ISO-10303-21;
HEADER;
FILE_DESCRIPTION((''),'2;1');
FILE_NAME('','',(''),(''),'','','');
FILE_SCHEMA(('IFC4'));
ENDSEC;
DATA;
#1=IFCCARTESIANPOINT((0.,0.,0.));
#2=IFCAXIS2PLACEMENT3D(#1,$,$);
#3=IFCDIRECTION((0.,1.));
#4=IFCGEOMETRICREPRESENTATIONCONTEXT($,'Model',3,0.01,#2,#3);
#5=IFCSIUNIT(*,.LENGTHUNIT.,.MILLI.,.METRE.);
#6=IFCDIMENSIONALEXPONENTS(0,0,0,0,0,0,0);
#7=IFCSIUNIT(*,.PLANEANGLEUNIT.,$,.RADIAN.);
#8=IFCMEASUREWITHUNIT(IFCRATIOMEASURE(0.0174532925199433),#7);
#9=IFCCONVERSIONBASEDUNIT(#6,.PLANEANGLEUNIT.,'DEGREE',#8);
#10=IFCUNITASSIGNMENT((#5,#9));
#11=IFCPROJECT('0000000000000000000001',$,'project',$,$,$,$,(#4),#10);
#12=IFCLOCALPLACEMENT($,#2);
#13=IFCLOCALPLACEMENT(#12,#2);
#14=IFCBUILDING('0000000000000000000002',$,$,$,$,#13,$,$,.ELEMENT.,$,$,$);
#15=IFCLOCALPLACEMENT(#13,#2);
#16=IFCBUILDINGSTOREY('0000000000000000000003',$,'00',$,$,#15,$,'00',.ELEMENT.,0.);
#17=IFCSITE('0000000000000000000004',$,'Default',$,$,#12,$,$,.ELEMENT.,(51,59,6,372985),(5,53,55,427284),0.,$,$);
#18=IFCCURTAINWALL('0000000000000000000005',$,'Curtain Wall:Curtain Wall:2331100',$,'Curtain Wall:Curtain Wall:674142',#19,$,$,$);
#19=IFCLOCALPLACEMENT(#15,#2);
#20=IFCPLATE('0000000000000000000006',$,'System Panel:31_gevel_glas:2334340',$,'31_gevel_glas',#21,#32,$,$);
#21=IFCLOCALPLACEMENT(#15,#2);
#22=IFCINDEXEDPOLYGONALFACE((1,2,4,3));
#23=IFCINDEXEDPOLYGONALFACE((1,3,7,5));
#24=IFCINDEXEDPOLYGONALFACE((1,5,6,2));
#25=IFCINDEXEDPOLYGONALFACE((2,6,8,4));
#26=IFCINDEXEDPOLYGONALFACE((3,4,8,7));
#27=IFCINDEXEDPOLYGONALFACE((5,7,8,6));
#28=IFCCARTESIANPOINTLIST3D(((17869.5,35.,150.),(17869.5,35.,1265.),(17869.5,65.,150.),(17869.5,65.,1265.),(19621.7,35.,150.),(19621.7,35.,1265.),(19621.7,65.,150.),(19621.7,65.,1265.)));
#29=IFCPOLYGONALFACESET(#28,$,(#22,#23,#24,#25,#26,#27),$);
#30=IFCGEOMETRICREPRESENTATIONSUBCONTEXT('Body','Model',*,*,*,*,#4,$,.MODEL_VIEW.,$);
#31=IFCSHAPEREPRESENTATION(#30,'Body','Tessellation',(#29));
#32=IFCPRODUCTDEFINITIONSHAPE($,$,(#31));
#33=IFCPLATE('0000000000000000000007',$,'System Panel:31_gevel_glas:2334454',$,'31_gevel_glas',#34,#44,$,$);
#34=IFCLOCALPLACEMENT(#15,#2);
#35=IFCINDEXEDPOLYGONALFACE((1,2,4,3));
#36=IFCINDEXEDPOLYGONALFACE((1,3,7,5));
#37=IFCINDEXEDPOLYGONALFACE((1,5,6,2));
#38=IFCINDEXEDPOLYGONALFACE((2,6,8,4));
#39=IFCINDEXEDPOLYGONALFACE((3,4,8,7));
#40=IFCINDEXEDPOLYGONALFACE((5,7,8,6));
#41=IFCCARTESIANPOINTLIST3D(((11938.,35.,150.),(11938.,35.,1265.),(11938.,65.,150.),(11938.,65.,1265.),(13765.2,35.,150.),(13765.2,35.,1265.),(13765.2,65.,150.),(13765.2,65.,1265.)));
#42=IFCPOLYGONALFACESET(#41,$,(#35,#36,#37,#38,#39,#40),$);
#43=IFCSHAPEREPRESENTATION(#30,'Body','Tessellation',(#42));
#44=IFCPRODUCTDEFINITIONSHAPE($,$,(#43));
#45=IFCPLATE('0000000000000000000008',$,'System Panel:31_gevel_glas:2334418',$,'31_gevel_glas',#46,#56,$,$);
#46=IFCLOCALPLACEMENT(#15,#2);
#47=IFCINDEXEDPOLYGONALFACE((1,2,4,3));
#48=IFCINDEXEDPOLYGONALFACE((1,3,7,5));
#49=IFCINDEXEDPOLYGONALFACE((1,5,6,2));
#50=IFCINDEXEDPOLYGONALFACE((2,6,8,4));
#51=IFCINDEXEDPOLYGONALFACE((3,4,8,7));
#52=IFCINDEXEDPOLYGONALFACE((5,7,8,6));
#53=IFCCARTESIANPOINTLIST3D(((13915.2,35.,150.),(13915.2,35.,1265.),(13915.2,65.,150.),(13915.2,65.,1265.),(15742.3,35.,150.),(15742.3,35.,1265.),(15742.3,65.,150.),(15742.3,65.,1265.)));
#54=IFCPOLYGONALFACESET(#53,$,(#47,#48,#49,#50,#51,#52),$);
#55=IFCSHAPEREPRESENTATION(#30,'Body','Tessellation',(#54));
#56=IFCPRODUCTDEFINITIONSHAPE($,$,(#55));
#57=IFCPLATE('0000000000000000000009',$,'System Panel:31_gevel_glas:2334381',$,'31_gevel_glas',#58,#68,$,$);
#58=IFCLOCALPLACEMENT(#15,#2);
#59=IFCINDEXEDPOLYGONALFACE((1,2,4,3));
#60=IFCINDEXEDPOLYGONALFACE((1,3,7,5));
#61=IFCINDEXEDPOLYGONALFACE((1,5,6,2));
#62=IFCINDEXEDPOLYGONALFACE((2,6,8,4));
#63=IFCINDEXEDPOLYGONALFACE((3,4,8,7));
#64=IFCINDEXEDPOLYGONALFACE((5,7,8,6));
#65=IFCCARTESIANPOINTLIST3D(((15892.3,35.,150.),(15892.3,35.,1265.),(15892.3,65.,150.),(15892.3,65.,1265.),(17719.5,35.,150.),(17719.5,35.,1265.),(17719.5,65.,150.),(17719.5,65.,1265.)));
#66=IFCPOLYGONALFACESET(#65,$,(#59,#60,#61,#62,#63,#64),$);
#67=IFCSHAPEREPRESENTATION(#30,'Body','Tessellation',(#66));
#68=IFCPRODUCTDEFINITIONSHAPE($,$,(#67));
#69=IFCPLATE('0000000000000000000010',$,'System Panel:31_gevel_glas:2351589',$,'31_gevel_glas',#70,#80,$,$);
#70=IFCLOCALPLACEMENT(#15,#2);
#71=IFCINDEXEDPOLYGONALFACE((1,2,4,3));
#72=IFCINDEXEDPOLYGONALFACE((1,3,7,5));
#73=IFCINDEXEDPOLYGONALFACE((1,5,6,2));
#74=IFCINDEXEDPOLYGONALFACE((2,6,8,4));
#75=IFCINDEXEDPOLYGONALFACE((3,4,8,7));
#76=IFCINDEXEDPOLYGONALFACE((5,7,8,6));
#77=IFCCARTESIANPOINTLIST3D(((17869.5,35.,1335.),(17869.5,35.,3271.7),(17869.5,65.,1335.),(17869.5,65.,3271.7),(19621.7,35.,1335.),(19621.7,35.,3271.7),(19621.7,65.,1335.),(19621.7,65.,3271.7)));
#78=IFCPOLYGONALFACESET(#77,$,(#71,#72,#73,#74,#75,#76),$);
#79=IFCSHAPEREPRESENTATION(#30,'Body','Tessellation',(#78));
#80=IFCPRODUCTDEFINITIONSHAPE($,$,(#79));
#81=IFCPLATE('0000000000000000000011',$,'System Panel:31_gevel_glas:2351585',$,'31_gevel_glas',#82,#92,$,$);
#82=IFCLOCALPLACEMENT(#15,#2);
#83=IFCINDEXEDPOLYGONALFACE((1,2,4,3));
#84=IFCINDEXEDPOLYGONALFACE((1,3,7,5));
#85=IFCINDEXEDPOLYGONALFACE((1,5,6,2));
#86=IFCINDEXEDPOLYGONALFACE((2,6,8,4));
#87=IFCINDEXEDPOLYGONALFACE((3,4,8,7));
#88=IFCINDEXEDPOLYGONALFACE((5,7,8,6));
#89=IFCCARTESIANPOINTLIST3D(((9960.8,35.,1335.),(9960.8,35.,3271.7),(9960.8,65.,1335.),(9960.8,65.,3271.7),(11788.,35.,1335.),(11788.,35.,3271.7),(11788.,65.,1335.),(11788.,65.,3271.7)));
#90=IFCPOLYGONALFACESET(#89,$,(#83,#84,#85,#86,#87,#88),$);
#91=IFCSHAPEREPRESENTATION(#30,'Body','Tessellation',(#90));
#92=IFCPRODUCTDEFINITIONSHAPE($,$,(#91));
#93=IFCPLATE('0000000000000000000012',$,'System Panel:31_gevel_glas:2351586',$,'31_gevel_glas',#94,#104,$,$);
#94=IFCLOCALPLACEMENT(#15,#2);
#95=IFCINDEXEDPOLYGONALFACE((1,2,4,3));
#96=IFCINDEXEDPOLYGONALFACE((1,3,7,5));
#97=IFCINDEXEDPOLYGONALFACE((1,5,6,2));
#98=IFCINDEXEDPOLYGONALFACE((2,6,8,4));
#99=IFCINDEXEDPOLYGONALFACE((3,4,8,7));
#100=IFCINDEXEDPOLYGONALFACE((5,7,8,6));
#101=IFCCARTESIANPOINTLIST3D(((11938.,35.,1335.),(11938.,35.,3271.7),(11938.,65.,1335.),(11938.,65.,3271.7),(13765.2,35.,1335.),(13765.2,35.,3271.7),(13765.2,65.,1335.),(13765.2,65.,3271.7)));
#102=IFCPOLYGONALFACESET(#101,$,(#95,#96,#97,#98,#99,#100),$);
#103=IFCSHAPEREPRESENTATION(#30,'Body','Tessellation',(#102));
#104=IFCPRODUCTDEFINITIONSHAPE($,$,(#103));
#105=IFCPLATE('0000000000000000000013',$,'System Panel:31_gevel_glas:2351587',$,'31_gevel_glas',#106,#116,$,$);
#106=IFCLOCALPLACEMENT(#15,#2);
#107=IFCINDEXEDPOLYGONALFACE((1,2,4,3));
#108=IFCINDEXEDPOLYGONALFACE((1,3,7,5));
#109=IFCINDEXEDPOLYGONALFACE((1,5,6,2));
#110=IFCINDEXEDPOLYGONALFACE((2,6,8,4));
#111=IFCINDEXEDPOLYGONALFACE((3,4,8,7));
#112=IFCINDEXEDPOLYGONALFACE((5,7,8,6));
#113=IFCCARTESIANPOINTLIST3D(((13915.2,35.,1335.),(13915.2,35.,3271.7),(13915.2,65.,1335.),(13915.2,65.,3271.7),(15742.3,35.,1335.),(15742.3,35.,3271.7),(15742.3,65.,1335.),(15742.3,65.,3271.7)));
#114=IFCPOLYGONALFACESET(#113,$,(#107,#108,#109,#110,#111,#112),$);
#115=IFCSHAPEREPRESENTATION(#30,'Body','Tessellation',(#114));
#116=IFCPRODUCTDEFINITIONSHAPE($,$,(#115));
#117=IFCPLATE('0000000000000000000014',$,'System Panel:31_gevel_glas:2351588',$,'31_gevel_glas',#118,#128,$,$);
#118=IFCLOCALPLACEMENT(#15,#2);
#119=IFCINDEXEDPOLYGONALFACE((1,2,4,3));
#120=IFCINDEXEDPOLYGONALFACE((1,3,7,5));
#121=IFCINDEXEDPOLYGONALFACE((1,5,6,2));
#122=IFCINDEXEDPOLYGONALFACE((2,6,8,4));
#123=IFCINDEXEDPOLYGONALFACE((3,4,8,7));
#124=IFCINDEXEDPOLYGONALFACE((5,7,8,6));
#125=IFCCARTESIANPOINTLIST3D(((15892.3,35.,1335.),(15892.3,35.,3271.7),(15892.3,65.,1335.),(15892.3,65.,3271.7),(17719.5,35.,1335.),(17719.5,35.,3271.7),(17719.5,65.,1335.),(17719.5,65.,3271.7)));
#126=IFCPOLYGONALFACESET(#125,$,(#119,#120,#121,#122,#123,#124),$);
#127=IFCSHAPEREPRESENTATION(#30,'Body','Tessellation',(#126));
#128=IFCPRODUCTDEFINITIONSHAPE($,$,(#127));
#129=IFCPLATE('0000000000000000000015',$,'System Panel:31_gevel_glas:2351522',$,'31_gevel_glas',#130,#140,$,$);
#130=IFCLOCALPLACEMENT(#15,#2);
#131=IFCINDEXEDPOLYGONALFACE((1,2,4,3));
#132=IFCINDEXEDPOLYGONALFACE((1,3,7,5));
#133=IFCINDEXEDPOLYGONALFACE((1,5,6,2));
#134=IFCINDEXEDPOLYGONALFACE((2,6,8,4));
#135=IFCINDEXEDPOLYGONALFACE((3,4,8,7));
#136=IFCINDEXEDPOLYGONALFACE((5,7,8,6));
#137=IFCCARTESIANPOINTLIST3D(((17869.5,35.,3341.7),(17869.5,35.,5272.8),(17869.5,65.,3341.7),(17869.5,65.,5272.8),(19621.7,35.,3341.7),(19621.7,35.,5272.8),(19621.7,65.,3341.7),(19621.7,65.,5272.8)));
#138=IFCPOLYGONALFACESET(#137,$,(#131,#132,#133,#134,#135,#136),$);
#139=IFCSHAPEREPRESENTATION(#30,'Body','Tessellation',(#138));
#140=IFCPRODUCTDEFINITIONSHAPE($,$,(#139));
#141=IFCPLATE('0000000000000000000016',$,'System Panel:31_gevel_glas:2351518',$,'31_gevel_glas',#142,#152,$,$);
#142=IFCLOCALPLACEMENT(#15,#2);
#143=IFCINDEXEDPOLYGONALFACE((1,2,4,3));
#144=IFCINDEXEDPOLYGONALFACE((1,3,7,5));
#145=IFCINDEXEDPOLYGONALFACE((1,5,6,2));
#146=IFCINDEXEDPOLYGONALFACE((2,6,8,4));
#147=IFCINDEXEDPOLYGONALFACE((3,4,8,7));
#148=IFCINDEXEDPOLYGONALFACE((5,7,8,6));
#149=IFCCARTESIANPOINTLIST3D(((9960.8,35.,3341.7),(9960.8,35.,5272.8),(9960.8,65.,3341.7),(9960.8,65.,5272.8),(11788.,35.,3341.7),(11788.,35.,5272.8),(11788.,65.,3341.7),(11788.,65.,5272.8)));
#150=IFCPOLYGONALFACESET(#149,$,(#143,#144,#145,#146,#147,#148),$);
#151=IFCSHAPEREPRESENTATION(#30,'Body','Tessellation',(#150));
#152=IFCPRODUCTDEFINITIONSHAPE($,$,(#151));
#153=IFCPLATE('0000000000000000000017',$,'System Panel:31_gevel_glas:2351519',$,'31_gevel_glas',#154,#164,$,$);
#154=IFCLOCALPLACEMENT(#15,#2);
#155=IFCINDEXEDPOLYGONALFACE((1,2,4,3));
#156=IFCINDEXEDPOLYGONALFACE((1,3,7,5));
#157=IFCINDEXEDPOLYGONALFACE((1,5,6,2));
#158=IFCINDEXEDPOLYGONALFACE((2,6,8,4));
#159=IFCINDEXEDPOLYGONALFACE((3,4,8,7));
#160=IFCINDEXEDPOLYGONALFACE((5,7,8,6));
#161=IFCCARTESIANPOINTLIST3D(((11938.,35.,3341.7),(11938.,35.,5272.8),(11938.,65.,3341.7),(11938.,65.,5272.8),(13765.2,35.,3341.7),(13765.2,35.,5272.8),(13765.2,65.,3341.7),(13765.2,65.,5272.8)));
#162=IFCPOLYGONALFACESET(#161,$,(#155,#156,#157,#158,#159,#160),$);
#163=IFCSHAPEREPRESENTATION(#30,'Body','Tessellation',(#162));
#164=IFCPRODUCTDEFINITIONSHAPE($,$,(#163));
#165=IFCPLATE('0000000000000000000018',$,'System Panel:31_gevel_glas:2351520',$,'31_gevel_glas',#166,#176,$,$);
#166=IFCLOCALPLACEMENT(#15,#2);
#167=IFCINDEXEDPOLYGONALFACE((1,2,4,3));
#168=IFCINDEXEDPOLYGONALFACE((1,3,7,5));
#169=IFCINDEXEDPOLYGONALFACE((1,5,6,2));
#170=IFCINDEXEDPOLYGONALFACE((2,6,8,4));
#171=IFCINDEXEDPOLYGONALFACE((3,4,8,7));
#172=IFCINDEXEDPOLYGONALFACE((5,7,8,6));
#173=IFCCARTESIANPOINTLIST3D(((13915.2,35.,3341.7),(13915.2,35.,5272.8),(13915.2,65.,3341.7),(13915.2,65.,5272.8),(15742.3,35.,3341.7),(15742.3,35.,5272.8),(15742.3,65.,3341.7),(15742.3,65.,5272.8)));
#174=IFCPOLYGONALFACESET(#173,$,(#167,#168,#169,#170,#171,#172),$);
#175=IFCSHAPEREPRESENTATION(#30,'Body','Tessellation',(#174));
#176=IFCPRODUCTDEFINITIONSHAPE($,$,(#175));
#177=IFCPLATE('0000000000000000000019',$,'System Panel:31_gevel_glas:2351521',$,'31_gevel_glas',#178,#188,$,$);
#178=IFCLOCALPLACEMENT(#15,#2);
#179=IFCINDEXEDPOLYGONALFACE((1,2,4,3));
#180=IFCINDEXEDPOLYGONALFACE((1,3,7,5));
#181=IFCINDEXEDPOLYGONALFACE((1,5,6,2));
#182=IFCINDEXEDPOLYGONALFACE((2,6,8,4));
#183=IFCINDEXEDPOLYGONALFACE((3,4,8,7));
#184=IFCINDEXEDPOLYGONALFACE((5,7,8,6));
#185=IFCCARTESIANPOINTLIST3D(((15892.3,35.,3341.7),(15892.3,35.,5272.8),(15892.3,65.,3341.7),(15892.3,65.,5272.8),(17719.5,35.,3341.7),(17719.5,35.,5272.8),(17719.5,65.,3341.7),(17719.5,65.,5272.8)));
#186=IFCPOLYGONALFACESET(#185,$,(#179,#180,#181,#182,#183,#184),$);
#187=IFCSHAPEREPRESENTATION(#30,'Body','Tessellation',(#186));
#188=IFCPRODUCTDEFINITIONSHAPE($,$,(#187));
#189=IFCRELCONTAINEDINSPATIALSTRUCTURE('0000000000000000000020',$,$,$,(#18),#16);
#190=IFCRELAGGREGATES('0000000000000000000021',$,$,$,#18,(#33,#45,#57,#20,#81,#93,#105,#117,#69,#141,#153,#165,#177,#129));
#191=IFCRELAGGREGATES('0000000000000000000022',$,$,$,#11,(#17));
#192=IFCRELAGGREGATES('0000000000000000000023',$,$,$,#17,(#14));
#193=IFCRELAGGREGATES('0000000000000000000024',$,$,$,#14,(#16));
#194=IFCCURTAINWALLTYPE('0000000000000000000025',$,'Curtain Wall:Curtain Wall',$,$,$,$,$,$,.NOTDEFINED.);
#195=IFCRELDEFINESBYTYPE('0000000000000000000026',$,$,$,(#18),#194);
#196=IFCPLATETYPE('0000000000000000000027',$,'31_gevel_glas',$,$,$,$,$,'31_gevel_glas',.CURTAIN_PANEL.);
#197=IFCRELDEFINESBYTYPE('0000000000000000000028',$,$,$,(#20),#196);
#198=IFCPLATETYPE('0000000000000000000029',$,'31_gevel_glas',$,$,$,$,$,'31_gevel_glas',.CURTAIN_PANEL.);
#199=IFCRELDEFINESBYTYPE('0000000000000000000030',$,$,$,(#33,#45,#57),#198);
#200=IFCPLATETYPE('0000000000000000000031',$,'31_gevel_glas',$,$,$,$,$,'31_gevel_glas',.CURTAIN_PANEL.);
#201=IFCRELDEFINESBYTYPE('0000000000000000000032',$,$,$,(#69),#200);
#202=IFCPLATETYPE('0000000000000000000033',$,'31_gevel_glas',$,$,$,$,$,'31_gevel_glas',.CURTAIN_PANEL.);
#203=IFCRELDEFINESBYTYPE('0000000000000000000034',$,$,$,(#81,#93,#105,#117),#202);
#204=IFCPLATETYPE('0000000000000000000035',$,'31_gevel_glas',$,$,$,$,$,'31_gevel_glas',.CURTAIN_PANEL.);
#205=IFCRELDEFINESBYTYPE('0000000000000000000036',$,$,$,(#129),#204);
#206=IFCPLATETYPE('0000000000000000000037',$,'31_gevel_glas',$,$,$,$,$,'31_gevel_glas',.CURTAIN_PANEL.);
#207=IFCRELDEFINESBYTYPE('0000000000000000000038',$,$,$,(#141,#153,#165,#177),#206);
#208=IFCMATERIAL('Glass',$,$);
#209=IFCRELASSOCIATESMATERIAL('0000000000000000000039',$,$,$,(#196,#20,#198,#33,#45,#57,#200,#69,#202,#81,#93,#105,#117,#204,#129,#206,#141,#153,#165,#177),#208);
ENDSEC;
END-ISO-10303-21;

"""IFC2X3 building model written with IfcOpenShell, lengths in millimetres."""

from ifc_helpers import new_model, entity, si_unit, converted_unit, direction, frame, origin, origin_2d_with_axis, place, context, subcontext, project, spatial, rectangle, extrude, source, transform, mapped, material, type_object, type_shapes, element, aggregate, save


model = new_model("IFC2X3")

# Units and contexts
model_context = context("Model", 3, precision=0.01, world=origin(), true_north=direction((0.0, 1.0)))
body_context = subcontext(model_context, "Body", "Model", "MODEL_VIEW")
ifc_project = project(units=[si_unit("LENGTHUNIT", "METRE", prefix="MILLI"), converted_unit("PLANEANGLEUNIT", "DEGREE", entity("IfcRatioMeasure", 0.0174532925199433), si_unit("PLANEANGLEUNIT", "RADIAN"), dimensions=[0, 0, 0, 0, 0, 0, 0])], contexts=[model_context])

# Site, building, storey
site_placement = place(None, origin())
site = spatial("IfcSite", under=ifc_project, at=site_placement, Name="Default", CompositionType="ELEMENT", RefLatitude=(51, 59, 6, 372985), RefLongitude=(5, 53, 55, 427284), RefElevation=0.0)
building_placement = place(site_placement, origin())
building = spatial("IfcBuilding", under=site, at=building_placement, CompositionType="ELEMENT")
storey_placement = place(building_placement, origin())
storey = spatial("IfcBuildingStorey", under=building, at=storey_placement, Name="00", LongName="00", CompositionType="ELEMENT", Elevation=0.0)

# Curtain wall, plates
curtain_wall_type = type_object("IfcCurtainWallType", Name="Curtain Wall:Curtain Wall", PredefinedType="NOTDEFINED")
curtain_wall_placement = place(storey_placement, origin())
curtain_wall = element("IfcCurtainWall", 1, at=curtain_wall_placement, inside=storey, type_object=curtain_wall_type, Name="Curtain Wall:Curtain Wall:2331100", ObjectType="Curtain Wall:Curtain Wall:674142")
ifc_material = material(Name="Glass")
plate_type_1 = type_object("IfcPlateType", Name="31_gevel_glas", ElementType="31_gevel_glas", PredefinedType="CURTAIN_PANEL", material=ifc_material)
shared_shape_1 = source(origin(), body_context, "Body", "SweptSolid", [
    extrude(rectangle(XDim=30.0, YDim=1752.2, at=origin_2d_with_axis()), frame((0.0, 50.0, 0.0), z_axis=(0.0, 0.0, 1.0), x_axis=(0.0, 1.0, 0.0)), (0.0, 0.0, 1.0), 1115.0),
])
type_shapes(plate_type_1, [shared_shape_1])
plate_1_placement = place(curtain_wall_placement, frame((18745.6, 0.0, 150.0)))
plate_1 = element("IfcPlate", 2, at=plate_1_placement, type_object=plate_type_1, material=ifc_material, Name="System Panel:31_gevel_glas:2334340", ObjectType="31_gevel_glas", context=body_context, shape_type="MappedRepresentation", body=[
    mapped(shared_shape_1, transform((0.0, 0.0, 0.0), scale=1.0)),
])
plate_type_2 = type_object("IfcPlateType", Name="31_gevel_glas", ElementType="31_gevel_glas", PredefinedType="CURTAIN_PANEL", material=ifc_material)
shared_shape_2 = source(origin(), body_context, "Body", "SweptSolid", [
    extrude(rectangle(XDim=30.0, YDim=1827.2, at=origin_2d_with_axis()), frame((0.0, 50.0, 0.0), z_axis=(0.0, 0.0, 1.0), x_axis=(0.0, 1.0, 0.0)), (0.0, 0.0, 1.0), 1115.0),
])
type_shapes(plate_type_2, [shared_shape_2])
plate_2_placement = place(curtain_wall_placement, frame((12851.6, 0.0, 150.0)))
plate_2 = element("IfcPlate", 3, at=plate_2_placement, type_object=plate_type_2, material=ifc_material, Name="System Panel:31_gevel_glas:2334454", ObjectType="31_gevel_glas", context=body_context, shape_type="MappedRepresentation", body=[
    mapped(shared_shape_2, transform((0.0, 0.0, 0.0), scale=1.0)),
])
plate_3_placement = place(curtain_wall_placement, frame((14828.8, 0.0, 150.0)))
plate_3 = element("IfcPlate", 4, at=plate_3_placement, type_object=plate_type_2, material=ifc_material, Name="System Panel:31_gevel_glas:2334418", ObjectType="31_gevel_glas", context=body_context, shape_type="MappedRepresentation", body=[
    mapped(shared_shape_2, transform((0.0, 0.0, 0.0), scale=1.0)),
])
plate_4_placement = place(curtain_wall_placement, frame((16805.9, 0.0, 150.0)))
plate_4 = element("IfcPlate", 5, at=plate_4_placement, type_object=plate_type_2, material=ifc_material, Name="System Panel:31_gevel_glas:2334381", ObjectType="31_gevel_glas", context=body_context, shape_type="MappedRepresentation", body=[
    mapped(shared_shape_2, transform((0.0, 0.0, 0.0), scale=1.0)),
])
plate_type_3 = type_object("IfcPlateType", Name="31_gevel_glas", ElementType="31_gevel_glas", PredefinedType="CURTAIN_PANEL", material=ifc_material)
shared_shape_3 = source(origin(), body_context, "Body", "SweptSolid", [
    extrude(rectangle(XDim=30.0, YDim=1752.2, at=origin_2d_with_axis()), frame((0.0, 50.0, 0.0), z_axis=(0.0, 0.0, 1.0), x_axis=(0.0, 1.0, 0.0)), (0.0, 0.0, 1.0), 1936.7),
])
type_shapes(plate_type_3, [shared_shape_3])
plate_5_placement = place(curtain_wall_placement, frame((18745.6, 0.0, 1335.0)))
plate_5 = element("IfcPlate", 6, at=plate_5_placement, type_object=plate_type_3, material=ifc_material, Name="System Panel:31_gevel_glas:2351589", ObjectType="31_gevel_glas", context=body_context, shape_type="MappedRepresentation", body=[
    mapped(shared_shape_3, transform((0.0, 0.0, 0.0), scale=1.0)),
])
plate_type_4 = type_object("IfcPlateType", Name="31_gevel_glas", ElementType="31_gevel_glas", PredefinedType="CURTAIN_PANEL", material=ifc_material)
shared_shape_4 = source(origin(), body_context, "Body", "SweptSolid", [
    extrude(rectangle(XDim=30.0, YDim=1827.2, at=origin_2d_with_axis()), frame((0.0, 50.0, 0.0), z_axis=(0.0, 0.0, 1.0), x_axis=(0.0, 1.0, 0.0)), (0.0, 0.0, 1.0), 1936.7),
])
type_shapes(plate_type_4, [shared_shape_4])
plate_6_placement = place(curtain_wall_placement, frame((10874.4, 0.0, 1335.0)))
plate_6 = element("IfcPlate", 7, at=plate_6_placement, type_object=plate_type_4, material=ifc_material, Name="System Panel:31_gevel_glas:2351585", ObjectType="31_gevel_glas", context=body_context, shape_type="MappedRepresentation", body=[
    mapped(shared_shape_4, transform((0.0, 0.0, 0.0), scale=1.0)),
])
plate_7_placement = place(curtain_wall_placement, frame((12851.6, 0.0, 1335.0)))
plate_7 = element("IfcPlate", 8, at=plate_7_placement, type_object=plate_type_4, material=ifc_material, Name="System Panel:31_gevel_glas:2351586", ObjectType="31_gevel_glas", context=body_context, shape_type="MappedRepresentation", body=[
    mapped(shared_shape_4, transform((0.0, 0.0, 0.0), scale=1.0)),
])
plate_8_placement = place(curtain_wall_placement, frame((14828.8, 0.0, 1335.0)))
plate_8 = element("IfcPlate", 9, at=plate_8_placement, type_object=plate_type_4, material=ifc_material, Name="System Panel:31_gevel_glas:2351587", ObjectType="31_gevel_glas", context=body_context, shape_type="MappedRepresentation", body=[
    mapped(shared_shape_4, transform((0.0, 0.0, 0.0), scale=1.0)),
])
plate_9_placement = place(curtain_wall_placement, frame((16805.9, 0.0, 1335.0)))
plate_9 = element("IfcPlate", 10, at=plate_9_placement, type_object=plate_type_4, material=ifc_material, Name="System Panel:31_gevel_glas:2351588", ObjectType="31_gevel_glas", context=body_context, shape_type="MappedRepresentation", body=[
    mapped(shared_shape_4, transform((0.0, 0.0, 0.0), scale=1.0)),
])
plate_type_5 = type_object("IfcPlateType", Name="31_gevel_glas", ElementType="31_gevel_glas", PredefinedType="CURTAIN_PANEL", material=ifc_material)
shared_shape_5 = source(origin(), body_context, "Body", "SweptSolid", [
    extrude(rectangle(XDim=30.0, YDim=1752.2, at=origin_2d_with_axis()), frame((0.0, 50.0, 0.0), z_axis=(0.0, 0.0, 1.0), x_axis=(0.0, 1.0, 0.0)), (0.0, 0.0, 1.0), 1931.1),
])
type_shapes(plate_type_5, [shared_shape_5])
plate_10_placement = place(curtain_wall_placement, frame((18745.6, 0.0, 3341.7)))
plate_10 = element("IfcPlate", 11, at=plate_10_placement, type_object=plate_type_5, material=ifc_material, Name="System Panel:31_gevel_glas:2351522", ObjectType="31_gevel_glas", context=body_context, shape_type="MappedRepresentation", body=[
    mapped(shared_shape_5, transform((0.0, 0.0, 0.0), scale=1.0)),
])
plate_type_6 = type_object("IfcPlateType", Name="31_gevel_glas", ElementType="31_gevel_glas", PredefinedType="CURTAIN_PANEL", material=ifc_material)
shared_shape_6 = source(origin(), body_context, "Body", "SweptSolid", [
    extrude(rectangle(XDim=30.0, YDim=1827.2, at=origin_2d_with_axis()), frame((0.0, 50.0, 0.0), z_axis=(0.0, 0.0, 1.0), x_axis=(0.0, 1.0, 0.0)), (0.0, 0.0, 1.0), 1931.1),
])
type_shapes(plate_type_6, [shared_shape_6])
plate_11_placement = place(curtain_wall_placement, frame((10874.4, 0.0, 3341.7)))
plate_11 = element("IfcPlate", 12, at=plate_11_placement, type_object=plate_type_6, material=ifc_material, Name="System Panel:31_gevel_glas:2351518", ObjectType="31_gevel_glas", context=body_context, shape_type="MappedRepresentation", body=[
    mapped(shared_shape_6, transform((0.0, 0.0, 0.0), scale=1.0)),
])
plate_12_placement = place(curtain_wall_placement, frame((12851.6, 0.0, 3341.7)))
plate_12 = element("IfcPlate", 13, at=plate_12_placement, type_object=plate_type_6, material=ifc_material, Name="System Panel:31_gevel_glas:2351519", ObjectType="31_gevel_glas", context=body_context, shape_type="MappedRepresentation", body=[
    mapped(shared_shape_6, transform((0.0, 0.0, 0.0), scale=1.0)),
])
plate_13_placement = place(curtain_wall_placement, frame((14828.8, 0.0, 3341.7)))
plate_13 = element("IfcPlate", 14, at=plate_13_placement, type_object=plate_type_6, material=ifc_material, Name="System Panel:31_gevel_glas:2351520", ObjectType="31_gevel_glas", context=body_context, shape_type="MappedRepresentation", body=[
    mapped(shared_shape_6, transform((0.0, 0.0, 0.0), scale=1.0)),
])
plate_14_placement = place(curtain_wall_placement, frame((16805.9, 0.0, 3341.7)))
plate_14 = element("IfcPlate", 15, at=plate_14_placement, type_object=plate_type_6, material=ifc_material, Name="System Panel:31_gevel_glas:2351521", ObjectType="31_gevel_glas", context=body_context, shape_type="MappedRepresentation", body=[
    mapped(shared_shape_6, transform((0.0, 0.0, 0.0), scale=1.0)),
])
aggregate(curtain_wall, [plate_2, plate_3, plate_4, plate_1, plate_6, plate_7, plate_8, plate_9, plate_5, plate_11, plate_12, plate_13, plate_14, plate_10])

save(model, "model.ifc")
